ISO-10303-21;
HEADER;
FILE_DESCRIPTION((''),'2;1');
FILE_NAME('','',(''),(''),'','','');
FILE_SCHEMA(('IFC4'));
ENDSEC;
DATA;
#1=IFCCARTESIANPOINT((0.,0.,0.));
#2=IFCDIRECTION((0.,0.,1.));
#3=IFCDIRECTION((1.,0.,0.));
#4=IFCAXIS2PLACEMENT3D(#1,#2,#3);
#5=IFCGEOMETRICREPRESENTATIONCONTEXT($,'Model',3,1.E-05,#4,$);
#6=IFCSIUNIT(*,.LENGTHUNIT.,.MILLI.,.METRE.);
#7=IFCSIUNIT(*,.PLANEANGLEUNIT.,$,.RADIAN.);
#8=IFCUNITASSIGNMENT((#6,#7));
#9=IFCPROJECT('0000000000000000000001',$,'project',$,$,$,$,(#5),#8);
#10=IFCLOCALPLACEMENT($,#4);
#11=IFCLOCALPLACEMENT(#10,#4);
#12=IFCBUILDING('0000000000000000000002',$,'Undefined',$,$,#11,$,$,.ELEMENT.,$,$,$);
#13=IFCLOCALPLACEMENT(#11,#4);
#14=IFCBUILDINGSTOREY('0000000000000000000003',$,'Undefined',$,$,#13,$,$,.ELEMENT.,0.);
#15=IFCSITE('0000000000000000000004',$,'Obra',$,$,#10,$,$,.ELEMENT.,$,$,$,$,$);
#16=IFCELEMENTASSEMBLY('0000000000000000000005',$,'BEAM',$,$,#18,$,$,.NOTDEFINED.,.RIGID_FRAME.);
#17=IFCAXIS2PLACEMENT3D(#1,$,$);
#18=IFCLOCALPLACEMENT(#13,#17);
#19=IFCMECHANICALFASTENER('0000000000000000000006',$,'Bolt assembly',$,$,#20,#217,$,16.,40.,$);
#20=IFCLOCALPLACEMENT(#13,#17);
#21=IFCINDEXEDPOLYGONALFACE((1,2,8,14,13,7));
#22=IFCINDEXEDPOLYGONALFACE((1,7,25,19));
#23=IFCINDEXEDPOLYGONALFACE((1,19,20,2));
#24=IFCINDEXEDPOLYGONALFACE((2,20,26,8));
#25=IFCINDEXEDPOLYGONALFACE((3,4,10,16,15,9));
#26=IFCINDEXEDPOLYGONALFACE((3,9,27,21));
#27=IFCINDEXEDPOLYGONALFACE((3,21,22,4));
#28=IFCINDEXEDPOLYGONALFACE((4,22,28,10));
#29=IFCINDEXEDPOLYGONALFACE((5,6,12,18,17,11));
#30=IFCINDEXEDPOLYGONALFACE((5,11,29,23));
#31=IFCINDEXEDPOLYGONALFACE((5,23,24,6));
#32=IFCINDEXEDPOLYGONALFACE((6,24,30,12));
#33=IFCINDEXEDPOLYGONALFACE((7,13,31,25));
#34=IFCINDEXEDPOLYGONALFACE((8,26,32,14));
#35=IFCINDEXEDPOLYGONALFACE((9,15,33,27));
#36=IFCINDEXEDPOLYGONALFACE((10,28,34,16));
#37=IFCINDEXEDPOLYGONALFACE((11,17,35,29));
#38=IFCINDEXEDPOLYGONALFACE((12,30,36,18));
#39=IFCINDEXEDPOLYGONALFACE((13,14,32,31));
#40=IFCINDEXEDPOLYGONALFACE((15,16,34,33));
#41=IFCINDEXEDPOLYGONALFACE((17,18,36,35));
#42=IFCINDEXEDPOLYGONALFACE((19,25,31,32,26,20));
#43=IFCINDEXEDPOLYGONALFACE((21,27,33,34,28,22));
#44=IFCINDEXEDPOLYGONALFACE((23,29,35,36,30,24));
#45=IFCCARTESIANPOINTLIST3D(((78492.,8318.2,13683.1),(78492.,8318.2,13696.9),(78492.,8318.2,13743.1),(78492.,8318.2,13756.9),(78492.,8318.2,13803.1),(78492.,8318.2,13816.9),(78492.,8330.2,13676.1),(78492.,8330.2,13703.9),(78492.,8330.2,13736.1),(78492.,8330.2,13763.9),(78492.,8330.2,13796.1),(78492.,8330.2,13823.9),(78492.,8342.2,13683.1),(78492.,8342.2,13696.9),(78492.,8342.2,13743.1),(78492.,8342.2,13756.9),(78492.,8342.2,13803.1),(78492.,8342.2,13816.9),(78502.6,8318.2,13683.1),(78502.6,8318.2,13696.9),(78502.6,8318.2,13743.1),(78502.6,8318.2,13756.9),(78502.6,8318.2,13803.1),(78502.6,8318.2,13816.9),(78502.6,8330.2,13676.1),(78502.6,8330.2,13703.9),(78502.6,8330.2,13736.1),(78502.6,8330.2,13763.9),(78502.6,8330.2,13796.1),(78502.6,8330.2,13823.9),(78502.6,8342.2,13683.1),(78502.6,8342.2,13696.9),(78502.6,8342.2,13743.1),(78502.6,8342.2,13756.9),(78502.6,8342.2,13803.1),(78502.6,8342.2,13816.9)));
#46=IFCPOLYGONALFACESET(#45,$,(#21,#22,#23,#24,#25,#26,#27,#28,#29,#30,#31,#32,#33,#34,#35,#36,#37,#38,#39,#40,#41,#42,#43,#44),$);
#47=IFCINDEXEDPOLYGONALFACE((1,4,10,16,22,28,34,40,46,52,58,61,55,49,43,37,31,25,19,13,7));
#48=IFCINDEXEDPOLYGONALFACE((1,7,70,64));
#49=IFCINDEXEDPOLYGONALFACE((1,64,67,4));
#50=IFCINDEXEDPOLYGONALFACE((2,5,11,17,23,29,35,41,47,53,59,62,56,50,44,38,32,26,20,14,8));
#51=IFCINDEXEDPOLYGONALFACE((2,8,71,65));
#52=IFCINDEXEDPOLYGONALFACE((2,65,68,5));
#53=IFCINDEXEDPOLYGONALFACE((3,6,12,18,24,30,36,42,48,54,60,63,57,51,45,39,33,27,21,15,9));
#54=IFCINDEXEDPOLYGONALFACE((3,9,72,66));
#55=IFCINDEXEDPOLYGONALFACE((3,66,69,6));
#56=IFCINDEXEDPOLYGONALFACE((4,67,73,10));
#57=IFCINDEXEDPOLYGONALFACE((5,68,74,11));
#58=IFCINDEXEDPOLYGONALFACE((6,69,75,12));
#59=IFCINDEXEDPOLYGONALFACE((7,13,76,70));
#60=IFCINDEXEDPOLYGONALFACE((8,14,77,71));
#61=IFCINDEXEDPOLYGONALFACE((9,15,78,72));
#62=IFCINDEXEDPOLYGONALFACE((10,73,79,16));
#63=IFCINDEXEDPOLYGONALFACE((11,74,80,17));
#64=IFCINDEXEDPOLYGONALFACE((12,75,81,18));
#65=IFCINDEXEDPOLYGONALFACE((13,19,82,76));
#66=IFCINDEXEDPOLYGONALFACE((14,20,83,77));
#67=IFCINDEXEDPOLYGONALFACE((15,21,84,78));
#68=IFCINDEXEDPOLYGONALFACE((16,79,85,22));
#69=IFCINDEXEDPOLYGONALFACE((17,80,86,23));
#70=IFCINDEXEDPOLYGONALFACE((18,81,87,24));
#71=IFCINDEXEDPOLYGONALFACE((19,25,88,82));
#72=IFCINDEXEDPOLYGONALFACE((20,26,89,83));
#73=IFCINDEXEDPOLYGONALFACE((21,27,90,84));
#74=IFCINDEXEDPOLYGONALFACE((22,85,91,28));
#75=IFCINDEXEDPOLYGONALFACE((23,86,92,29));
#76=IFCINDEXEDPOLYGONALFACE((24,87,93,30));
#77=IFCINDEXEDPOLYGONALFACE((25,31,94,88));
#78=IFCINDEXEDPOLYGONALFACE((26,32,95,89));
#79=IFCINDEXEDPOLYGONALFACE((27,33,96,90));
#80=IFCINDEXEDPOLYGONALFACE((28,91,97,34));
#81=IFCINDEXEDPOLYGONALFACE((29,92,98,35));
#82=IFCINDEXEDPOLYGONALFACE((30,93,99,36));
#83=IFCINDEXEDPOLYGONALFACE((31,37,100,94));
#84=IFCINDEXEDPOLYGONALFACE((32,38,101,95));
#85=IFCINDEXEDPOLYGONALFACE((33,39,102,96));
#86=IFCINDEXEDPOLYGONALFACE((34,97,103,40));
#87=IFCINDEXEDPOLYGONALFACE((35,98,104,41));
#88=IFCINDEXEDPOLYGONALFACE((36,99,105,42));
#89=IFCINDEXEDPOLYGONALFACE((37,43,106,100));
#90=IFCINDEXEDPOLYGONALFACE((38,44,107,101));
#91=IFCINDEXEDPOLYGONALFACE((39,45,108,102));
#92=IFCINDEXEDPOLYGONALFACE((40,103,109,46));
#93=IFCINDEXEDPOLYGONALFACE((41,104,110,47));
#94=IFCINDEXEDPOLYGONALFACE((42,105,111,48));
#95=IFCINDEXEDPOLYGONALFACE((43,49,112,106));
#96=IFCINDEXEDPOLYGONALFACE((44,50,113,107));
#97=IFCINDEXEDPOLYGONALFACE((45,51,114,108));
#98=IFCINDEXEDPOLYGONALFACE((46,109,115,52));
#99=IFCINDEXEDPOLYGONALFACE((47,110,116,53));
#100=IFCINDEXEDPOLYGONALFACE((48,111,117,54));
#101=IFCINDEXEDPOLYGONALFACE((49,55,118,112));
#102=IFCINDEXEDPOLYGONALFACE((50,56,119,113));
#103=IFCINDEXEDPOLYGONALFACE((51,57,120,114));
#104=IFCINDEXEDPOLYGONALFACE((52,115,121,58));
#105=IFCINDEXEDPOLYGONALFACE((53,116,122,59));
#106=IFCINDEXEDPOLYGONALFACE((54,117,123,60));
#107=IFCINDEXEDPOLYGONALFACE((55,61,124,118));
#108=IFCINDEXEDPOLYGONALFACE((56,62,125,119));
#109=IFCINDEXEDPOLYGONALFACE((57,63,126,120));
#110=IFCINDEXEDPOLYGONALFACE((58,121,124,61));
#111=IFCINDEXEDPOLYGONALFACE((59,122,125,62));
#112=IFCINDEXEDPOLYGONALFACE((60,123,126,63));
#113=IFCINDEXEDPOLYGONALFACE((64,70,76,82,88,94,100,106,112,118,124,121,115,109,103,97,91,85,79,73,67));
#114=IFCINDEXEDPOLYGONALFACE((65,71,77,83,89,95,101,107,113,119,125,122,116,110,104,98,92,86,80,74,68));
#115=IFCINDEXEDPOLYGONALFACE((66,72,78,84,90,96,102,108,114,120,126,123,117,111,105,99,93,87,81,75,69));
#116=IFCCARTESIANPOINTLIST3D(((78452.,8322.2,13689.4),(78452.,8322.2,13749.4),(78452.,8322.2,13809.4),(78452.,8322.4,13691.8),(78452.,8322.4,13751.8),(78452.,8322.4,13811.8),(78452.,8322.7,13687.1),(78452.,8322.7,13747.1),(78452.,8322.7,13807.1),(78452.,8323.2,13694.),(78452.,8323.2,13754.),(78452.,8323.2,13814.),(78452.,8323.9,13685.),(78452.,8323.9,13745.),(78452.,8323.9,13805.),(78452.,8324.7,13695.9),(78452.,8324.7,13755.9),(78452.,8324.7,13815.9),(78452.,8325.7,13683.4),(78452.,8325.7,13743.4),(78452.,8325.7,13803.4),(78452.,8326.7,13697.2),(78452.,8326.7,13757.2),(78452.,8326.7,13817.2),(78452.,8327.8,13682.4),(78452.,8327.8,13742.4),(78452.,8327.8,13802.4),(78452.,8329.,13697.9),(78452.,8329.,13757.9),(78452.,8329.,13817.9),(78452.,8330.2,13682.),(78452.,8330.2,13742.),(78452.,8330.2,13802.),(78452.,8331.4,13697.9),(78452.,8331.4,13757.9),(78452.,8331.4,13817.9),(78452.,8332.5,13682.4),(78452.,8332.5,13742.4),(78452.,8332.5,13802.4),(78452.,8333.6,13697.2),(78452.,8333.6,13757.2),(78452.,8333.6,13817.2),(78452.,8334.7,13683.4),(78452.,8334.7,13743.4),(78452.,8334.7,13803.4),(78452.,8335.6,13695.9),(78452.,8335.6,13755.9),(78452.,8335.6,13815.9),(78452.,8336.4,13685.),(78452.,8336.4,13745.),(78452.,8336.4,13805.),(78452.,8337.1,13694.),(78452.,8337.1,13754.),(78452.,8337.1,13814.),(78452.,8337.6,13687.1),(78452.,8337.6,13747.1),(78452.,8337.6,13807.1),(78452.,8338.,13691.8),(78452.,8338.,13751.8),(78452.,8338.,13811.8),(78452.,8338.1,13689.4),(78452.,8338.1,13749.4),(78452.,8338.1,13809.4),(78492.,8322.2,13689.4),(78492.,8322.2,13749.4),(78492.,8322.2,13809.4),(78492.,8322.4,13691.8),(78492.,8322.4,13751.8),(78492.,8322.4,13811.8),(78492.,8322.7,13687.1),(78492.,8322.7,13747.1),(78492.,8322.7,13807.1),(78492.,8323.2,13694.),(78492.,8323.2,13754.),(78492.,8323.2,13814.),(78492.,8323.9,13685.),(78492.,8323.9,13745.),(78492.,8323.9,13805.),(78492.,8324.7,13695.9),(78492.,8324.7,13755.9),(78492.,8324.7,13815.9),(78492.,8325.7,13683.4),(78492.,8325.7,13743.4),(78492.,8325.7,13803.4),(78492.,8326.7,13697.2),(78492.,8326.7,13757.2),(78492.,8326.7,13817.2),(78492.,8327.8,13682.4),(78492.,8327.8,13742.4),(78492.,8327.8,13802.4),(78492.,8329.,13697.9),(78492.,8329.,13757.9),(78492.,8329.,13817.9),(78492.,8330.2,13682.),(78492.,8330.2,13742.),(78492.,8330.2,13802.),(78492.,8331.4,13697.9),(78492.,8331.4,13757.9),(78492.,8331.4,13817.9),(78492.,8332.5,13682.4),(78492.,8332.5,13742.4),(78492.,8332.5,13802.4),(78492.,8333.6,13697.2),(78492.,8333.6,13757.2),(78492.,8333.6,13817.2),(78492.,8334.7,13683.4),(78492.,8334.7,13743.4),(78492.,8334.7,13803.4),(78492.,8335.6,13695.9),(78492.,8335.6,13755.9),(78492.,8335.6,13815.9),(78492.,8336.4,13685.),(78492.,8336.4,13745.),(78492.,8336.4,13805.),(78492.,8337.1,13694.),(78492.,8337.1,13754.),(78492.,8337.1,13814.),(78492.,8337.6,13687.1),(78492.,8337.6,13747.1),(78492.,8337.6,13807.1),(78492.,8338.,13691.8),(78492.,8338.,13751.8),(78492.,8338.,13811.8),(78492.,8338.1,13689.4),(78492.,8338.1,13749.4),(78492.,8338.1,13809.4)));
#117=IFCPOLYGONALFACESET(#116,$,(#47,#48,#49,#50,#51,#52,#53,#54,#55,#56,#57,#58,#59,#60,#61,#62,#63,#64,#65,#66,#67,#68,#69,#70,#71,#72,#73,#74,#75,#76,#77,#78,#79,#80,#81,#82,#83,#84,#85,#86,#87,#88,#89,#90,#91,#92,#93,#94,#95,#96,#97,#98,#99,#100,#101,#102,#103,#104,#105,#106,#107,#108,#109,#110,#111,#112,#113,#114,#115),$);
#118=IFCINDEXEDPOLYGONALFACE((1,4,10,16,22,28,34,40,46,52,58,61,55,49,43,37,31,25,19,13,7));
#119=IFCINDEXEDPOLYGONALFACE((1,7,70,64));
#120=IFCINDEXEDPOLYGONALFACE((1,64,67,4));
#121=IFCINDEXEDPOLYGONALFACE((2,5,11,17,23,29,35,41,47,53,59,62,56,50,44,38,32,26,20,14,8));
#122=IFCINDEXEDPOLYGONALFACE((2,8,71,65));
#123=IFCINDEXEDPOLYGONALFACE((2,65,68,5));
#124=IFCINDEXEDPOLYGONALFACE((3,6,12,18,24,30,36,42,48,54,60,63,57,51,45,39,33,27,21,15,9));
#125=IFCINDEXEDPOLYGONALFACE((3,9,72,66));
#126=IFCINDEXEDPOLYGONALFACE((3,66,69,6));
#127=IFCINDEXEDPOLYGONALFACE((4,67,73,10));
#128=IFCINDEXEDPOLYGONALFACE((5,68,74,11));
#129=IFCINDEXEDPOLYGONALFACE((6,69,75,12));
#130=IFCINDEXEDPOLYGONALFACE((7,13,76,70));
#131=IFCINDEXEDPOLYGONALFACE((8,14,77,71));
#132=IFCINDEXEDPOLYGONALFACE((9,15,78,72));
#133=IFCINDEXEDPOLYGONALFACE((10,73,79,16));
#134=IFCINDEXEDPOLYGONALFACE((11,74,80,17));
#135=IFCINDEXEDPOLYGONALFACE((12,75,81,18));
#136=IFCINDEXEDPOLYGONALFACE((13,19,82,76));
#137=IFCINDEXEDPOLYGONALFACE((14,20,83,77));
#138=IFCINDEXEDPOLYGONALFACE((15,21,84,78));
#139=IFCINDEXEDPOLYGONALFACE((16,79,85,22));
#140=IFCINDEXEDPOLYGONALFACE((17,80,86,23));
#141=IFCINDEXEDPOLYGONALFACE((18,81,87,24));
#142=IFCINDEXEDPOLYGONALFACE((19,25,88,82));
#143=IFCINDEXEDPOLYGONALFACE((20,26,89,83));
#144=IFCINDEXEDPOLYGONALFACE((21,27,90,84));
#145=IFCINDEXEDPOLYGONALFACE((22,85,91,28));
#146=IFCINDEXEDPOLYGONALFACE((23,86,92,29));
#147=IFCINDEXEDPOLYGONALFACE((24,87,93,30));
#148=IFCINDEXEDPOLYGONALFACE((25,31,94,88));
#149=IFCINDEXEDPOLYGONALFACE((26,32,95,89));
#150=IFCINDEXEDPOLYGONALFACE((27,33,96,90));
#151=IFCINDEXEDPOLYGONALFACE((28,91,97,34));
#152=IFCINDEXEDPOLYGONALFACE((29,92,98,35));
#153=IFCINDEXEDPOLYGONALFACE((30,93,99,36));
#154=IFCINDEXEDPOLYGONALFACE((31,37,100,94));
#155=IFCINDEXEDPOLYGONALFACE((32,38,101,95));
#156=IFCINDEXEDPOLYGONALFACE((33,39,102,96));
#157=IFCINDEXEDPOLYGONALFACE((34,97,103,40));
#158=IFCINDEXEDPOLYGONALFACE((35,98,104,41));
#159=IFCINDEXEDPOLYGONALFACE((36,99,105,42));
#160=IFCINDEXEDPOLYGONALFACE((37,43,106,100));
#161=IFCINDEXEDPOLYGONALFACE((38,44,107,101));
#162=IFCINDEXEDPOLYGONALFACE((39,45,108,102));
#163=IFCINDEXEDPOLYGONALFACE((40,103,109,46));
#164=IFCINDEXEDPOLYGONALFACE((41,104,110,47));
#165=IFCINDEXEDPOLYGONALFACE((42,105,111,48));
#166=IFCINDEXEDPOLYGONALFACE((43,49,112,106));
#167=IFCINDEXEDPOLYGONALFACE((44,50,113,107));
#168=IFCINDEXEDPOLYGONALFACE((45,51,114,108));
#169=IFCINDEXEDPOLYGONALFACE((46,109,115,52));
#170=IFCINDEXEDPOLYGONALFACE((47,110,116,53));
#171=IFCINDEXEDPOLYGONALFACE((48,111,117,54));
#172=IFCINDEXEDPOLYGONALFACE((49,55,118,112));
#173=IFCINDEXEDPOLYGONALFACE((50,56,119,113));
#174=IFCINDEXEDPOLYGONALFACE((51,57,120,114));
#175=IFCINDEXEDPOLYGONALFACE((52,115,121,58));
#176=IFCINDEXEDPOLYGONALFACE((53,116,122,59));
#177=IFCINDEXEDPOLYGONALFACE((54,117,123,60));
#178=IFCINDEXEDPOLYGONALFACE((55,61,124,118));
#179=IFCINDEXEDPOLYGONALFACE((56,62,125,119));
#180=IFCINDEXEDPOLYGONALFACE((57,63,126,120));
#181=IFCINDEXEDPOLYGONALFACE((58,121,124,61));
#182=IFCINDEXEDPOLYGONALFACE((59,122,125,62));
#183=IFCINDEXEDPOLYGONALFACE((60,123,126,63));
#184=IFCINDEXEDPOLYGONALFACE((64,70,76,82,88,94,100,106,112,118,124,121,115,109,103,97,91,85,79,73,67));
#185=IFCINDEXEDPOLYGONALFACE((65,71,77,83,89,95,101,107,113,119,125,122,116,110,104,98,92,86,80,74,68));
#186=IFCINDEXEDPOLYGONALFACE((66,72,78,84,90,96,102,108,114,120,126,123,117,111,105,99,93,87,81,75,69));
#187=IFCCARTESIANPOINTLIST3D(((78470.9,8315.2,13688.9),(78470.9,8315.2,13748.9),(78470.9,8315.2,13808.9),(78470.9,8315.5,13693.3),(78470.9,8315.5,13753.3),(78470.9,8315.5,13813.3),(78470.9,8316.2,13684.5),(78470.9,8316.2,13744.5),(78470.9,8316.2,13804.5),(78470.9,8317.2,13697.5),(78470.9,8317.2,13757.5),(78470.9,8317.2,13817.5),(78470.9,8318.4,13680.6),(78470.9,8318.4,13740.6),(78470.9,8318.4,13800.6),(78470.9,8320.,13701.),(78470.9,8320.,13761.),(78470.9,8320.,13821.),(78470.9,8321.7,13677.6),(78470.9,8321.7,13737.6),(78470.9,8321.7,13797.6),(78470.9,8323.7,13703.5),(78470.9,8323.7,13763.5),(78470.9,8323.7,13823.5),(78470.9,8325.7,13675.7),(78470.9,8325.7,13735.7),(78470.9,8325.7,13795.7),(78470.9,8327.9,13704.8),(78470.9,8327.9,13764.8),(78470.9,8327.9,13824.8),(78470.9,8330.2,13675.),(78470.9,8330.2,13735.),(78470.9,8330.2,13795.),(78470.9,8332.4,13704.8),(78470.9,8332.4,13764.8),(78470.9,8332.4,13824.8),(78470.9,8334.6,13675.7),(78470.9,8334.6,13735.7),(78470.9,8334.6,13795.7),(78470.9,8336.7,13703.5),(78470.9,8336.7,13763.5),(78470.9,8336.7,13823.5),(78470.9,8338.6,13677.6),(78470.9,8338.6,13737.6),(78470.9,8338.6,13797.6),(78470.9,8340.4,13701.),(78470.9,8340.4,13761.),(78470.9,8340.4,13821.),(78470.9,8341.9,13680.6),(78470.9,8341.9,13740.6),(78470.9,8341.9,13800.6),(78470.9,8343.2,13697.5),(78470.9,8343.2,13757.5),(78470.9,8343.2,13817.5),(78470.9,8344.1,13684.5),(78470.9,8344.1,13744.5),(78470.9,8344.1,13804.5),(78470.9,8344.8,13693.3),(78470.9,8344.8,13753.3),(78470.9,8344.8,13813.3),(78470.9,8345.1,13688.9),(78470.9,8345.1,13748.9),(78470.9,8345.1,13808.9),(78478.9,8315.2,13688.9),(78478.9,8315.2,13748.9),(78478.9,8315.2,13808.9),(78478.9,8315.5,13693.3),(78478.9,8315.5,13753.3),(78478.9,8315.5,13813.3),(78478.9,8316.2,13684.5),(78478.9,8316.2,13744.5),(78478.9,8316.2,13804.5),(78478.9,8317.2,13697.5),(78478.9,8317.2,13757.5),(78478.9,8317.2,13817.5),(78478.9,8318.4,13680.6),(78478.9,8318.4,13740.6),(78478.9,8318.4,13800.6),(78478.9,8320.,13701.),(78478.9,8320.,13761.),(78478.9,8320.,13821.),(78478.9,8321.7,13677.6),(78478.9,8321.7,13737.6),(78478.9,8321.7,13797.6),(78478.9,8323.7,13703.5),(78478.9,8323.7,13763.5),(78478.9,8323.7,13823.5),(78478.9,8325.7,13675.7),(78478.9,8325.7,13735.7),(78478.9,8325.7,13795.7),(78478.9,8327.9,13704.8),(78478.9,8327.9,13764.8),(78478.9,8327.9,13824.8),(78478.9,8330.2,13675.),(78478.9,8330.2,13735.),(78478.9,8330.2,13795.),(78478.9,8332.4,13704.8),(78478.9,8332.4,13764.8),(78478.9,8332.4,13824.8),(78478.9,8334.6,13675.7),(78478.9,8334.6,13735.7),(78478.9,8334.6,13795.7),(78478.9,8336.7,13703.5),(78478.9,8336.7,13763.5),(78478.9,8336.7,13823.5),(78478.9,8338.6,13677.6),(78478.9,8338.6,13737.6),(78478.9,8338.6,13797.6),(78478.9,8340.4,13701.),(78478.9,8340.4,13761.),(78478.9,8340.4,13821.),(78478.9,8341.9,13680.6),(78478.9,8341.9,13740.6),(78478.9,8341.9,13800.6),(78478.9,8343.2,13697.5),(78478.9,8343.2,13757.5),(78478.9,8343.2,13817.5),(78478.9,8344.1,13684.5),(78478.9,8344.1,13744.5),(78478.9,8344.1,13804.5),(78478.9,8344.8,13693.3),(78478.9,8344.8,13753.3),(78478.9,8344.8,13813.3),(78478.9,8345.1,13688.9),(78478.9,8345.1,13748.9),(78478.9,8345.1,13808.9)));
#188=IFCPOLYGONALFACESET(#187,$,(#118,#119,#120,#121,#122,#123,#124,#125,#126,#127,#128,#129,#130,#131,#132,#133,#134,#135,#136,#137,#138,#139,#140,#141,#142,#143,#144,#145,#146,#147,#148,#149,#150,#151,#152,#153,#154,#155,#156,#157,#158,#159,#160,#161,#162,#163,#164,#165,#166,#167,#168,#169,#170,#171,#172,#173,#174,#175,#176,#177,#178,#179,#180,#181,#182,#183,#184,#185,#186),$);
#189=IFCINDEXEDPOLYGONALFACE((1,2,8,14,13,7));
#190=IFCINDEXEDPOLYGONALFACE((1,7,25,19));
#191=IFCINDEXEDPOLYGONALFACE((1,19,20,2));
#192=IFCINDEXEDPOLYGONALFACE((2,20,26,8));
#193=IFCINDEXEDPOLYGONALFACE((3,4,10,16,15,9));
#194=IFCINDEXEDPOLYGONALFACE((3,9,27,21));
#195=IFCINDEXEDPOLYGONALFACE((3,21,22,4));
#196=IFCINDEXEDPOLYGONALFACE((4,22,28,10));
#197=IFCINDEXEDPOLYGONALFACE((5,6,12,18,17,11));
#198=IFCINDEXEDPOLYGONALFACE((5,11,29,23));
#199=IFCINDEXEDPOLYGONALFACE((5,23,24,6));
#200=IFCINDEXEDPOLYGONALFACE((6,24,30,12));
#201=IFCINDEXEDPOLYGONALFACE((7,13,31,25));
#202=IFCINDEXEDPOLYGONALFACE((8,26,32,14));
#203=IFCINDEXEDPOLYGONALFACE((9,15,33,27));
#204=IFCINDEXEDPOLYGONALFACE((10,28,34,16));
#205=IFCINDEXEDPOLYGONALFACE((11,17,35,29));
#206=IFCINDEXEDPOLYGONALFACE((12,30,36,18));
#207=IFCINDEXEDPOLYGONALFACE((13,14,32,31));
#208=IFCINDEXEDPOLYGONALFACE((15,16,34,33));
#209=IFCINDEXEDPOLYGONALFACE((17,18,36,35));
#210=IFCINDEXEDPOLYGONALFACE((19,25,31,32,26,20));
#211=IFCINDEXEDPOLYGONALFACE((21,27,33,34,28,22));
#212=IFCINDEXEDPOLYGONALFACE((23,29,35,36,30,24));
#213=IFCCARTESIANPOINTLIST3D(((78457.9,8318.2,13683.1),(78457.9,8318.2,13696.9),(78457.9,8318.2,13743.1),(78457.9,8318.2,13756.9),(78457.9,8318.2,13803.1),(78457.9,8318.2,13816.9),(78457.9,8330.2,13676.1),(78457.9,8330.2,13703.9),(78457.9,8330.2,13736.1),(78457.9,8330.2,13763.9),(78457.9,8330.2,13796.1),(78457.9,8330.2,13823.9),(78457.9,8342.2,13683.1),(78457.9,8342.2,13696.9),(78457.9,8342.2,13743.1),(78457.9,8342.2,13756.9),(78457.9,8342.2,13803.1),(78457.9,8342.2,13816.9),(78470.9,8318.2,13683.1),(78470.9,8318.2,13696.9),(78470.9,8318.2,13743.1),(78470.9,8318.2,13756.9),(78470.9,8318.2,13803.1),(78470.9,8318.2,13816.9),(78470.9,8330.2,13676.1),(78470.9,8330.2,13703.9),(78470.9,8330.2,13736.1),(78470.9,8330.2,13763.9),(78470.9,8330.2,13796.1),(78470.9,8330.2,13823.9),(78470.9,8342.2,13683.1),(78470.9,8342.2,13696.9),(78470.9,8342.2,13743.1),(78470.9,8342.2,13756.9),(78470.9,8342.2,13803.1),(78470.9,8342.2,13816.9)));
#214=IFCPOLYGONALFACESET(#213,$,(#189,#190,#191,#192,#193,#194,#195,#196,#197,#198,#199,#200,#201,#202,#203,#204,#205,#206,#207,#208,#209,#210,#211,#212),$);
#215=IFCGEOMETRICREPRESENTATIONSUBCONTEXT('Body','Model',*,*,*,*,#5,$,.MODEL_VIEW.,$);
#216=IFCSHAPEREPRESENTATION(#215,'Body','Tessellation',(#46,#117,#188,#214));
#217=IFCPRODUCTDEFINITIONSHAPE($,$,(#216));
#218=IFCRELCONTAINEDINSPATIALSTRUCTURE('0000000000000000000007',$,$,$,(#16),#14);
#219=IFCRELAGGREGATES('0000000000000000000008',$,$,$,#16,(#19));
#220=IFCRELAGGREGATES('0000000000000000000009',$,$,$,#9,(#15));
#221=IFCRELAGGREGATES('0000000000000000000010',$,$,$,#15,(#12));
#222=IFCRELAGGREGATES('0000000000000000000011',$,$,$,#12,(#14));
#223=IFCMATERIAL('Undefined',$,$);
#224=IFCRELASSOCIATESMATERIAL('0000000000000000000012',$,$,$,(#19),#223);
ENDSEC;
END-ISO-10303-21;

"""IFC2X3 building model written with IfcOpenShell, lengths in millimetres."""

from ifc_helpers import new_model, si_unit, frame, origin_with_axes, origin_2d_with_axis, place, context, subcontext, project, spatial, polyline, circle, outline, extrude, source, transform, mapped, material, element, aggregate, save


model = new_model("IFC2X3")

# Units and contexts
model_context = context("Model", 3, precision=1e-05, world=origin_with_axes())
body_context = subcontext(model_context, "Body", "Model", "MODEL_VIEW")
ifc_project = project(units=[si_unit("LENGTHUNIT", "METRE", prefix="MILLI"), si_unit("PLANEANGLEUNIT", "RADIAN")], contexts=[model_context])

# Site, building, storey
site_placement = place(None, origin_with_axes())
site = spatial("IfcSite", under=ifc_project, at=site_placement, Name="Obra", CompositionType="ELEMENT")
building_placement = place(site_placement, origin_with_axes())
building = spatial("IfcBuilding", under=site, at=building_placement, Name="Undefined", CompositionType="ELEMENT")
storey_placement = place(building_placement, origin_with_axes())
storey = spatial("IfcBuildingStorey", under=building, at=storey_placement, Name="Undefined", CompositionType="ELEMENT", Elevation=0.0)

# Element assembly
assembly_1_placement = place(storey_placement, origin_with_axes())
assembly_1 = element("IfcElementAssembly", 1, at=assembly_1_placement, inside=storey, Name="BEAM", AssemblyPlace="NOTDEFINED", PredefinedType="RIGID_FRAME")

# Shared definitions
ifc_material_1 = material(Name="Undefined")

# Shared definitions
shared_shape_1 = source(origin_with_axes(), body_context, "Body", "SweptSolid", [
    extrude(outline(polyline([(13.9, 0.0), (6.9, 12.0), (-6.9, 12.0), (-13.9, 0.0), (-6.9, -12.0), (6.9, -12.0), (13.9, 0.0)])), frame((0.0, -20.1, 0.0), z_axis=(0.0, 1.0, 0.0), x_axis=(1.0, 0.0, 0.0)), (0.0, 0.0, 1.0), 10.6),
    extrude(circle(Radius=8.0, at=origin_2d_with_axis()), frame((0.0, -9.6, 0.0), z_axis=(0.0, 1.0, 0.0), x_axis=(1.0, 0.0, 0.0)), (0.0, 0.0, 1.0), 40.0),
    extrude(circle(Radius=15.0, at=origin_2d_with_axis()), frame((0.0, 3.5, 0.0), z_axis=(0.0, 1.0, 0.0), x_axis=(1.0, 0.0, 0.0)), (0.0, 0.0, 1.0), 8.0),
    extrude(outline(polyline([(13.9, 0.0), (6.9, 12.0), (-6.9, 12.0), (-13.9, 0.0), (-6.9, -12.0), (6.9, -12.0), (13.9, 0.0)])), frame((0.0, 11.5, 0.0), z_axis=(0.0, 1.0, 0.0), x_axis=(1.0, 0.0, 0.0)), (0.0, 0.0, 1.0), 13.0),
])

# Mechanical fastener
mechanical_fastener_1_placement = place(assembly_1_placement, frame((78482.5, 8280.2, 13845.0), z_axis=(-0.000014, 1.0, 0.0), x_axis=(0.0, 0.0, -1.0)))
mechanical_fastener_1 = element("IfcMechanicalFastener", 2, at=mechanical_fastener_1_placement, material=ifc_material_1, Name="Bolt assembly", NominalDiameter=16.0, NominalLength=40.0, context=body_context, shape_type="MappedRepresentation", body=[
    mapped(shared_shape_1, transform((35.0, 0.0, 50.0))),
    mapped(shared_shape_1, transform((95.0, 0.0, 50.0))),
    mapped(shared_shape_1, transform((155.0, 0.0, 50.0))),
])
aggregate(assembly_1, [mechanical_fastener_1])

save(model, "model.ifc")
